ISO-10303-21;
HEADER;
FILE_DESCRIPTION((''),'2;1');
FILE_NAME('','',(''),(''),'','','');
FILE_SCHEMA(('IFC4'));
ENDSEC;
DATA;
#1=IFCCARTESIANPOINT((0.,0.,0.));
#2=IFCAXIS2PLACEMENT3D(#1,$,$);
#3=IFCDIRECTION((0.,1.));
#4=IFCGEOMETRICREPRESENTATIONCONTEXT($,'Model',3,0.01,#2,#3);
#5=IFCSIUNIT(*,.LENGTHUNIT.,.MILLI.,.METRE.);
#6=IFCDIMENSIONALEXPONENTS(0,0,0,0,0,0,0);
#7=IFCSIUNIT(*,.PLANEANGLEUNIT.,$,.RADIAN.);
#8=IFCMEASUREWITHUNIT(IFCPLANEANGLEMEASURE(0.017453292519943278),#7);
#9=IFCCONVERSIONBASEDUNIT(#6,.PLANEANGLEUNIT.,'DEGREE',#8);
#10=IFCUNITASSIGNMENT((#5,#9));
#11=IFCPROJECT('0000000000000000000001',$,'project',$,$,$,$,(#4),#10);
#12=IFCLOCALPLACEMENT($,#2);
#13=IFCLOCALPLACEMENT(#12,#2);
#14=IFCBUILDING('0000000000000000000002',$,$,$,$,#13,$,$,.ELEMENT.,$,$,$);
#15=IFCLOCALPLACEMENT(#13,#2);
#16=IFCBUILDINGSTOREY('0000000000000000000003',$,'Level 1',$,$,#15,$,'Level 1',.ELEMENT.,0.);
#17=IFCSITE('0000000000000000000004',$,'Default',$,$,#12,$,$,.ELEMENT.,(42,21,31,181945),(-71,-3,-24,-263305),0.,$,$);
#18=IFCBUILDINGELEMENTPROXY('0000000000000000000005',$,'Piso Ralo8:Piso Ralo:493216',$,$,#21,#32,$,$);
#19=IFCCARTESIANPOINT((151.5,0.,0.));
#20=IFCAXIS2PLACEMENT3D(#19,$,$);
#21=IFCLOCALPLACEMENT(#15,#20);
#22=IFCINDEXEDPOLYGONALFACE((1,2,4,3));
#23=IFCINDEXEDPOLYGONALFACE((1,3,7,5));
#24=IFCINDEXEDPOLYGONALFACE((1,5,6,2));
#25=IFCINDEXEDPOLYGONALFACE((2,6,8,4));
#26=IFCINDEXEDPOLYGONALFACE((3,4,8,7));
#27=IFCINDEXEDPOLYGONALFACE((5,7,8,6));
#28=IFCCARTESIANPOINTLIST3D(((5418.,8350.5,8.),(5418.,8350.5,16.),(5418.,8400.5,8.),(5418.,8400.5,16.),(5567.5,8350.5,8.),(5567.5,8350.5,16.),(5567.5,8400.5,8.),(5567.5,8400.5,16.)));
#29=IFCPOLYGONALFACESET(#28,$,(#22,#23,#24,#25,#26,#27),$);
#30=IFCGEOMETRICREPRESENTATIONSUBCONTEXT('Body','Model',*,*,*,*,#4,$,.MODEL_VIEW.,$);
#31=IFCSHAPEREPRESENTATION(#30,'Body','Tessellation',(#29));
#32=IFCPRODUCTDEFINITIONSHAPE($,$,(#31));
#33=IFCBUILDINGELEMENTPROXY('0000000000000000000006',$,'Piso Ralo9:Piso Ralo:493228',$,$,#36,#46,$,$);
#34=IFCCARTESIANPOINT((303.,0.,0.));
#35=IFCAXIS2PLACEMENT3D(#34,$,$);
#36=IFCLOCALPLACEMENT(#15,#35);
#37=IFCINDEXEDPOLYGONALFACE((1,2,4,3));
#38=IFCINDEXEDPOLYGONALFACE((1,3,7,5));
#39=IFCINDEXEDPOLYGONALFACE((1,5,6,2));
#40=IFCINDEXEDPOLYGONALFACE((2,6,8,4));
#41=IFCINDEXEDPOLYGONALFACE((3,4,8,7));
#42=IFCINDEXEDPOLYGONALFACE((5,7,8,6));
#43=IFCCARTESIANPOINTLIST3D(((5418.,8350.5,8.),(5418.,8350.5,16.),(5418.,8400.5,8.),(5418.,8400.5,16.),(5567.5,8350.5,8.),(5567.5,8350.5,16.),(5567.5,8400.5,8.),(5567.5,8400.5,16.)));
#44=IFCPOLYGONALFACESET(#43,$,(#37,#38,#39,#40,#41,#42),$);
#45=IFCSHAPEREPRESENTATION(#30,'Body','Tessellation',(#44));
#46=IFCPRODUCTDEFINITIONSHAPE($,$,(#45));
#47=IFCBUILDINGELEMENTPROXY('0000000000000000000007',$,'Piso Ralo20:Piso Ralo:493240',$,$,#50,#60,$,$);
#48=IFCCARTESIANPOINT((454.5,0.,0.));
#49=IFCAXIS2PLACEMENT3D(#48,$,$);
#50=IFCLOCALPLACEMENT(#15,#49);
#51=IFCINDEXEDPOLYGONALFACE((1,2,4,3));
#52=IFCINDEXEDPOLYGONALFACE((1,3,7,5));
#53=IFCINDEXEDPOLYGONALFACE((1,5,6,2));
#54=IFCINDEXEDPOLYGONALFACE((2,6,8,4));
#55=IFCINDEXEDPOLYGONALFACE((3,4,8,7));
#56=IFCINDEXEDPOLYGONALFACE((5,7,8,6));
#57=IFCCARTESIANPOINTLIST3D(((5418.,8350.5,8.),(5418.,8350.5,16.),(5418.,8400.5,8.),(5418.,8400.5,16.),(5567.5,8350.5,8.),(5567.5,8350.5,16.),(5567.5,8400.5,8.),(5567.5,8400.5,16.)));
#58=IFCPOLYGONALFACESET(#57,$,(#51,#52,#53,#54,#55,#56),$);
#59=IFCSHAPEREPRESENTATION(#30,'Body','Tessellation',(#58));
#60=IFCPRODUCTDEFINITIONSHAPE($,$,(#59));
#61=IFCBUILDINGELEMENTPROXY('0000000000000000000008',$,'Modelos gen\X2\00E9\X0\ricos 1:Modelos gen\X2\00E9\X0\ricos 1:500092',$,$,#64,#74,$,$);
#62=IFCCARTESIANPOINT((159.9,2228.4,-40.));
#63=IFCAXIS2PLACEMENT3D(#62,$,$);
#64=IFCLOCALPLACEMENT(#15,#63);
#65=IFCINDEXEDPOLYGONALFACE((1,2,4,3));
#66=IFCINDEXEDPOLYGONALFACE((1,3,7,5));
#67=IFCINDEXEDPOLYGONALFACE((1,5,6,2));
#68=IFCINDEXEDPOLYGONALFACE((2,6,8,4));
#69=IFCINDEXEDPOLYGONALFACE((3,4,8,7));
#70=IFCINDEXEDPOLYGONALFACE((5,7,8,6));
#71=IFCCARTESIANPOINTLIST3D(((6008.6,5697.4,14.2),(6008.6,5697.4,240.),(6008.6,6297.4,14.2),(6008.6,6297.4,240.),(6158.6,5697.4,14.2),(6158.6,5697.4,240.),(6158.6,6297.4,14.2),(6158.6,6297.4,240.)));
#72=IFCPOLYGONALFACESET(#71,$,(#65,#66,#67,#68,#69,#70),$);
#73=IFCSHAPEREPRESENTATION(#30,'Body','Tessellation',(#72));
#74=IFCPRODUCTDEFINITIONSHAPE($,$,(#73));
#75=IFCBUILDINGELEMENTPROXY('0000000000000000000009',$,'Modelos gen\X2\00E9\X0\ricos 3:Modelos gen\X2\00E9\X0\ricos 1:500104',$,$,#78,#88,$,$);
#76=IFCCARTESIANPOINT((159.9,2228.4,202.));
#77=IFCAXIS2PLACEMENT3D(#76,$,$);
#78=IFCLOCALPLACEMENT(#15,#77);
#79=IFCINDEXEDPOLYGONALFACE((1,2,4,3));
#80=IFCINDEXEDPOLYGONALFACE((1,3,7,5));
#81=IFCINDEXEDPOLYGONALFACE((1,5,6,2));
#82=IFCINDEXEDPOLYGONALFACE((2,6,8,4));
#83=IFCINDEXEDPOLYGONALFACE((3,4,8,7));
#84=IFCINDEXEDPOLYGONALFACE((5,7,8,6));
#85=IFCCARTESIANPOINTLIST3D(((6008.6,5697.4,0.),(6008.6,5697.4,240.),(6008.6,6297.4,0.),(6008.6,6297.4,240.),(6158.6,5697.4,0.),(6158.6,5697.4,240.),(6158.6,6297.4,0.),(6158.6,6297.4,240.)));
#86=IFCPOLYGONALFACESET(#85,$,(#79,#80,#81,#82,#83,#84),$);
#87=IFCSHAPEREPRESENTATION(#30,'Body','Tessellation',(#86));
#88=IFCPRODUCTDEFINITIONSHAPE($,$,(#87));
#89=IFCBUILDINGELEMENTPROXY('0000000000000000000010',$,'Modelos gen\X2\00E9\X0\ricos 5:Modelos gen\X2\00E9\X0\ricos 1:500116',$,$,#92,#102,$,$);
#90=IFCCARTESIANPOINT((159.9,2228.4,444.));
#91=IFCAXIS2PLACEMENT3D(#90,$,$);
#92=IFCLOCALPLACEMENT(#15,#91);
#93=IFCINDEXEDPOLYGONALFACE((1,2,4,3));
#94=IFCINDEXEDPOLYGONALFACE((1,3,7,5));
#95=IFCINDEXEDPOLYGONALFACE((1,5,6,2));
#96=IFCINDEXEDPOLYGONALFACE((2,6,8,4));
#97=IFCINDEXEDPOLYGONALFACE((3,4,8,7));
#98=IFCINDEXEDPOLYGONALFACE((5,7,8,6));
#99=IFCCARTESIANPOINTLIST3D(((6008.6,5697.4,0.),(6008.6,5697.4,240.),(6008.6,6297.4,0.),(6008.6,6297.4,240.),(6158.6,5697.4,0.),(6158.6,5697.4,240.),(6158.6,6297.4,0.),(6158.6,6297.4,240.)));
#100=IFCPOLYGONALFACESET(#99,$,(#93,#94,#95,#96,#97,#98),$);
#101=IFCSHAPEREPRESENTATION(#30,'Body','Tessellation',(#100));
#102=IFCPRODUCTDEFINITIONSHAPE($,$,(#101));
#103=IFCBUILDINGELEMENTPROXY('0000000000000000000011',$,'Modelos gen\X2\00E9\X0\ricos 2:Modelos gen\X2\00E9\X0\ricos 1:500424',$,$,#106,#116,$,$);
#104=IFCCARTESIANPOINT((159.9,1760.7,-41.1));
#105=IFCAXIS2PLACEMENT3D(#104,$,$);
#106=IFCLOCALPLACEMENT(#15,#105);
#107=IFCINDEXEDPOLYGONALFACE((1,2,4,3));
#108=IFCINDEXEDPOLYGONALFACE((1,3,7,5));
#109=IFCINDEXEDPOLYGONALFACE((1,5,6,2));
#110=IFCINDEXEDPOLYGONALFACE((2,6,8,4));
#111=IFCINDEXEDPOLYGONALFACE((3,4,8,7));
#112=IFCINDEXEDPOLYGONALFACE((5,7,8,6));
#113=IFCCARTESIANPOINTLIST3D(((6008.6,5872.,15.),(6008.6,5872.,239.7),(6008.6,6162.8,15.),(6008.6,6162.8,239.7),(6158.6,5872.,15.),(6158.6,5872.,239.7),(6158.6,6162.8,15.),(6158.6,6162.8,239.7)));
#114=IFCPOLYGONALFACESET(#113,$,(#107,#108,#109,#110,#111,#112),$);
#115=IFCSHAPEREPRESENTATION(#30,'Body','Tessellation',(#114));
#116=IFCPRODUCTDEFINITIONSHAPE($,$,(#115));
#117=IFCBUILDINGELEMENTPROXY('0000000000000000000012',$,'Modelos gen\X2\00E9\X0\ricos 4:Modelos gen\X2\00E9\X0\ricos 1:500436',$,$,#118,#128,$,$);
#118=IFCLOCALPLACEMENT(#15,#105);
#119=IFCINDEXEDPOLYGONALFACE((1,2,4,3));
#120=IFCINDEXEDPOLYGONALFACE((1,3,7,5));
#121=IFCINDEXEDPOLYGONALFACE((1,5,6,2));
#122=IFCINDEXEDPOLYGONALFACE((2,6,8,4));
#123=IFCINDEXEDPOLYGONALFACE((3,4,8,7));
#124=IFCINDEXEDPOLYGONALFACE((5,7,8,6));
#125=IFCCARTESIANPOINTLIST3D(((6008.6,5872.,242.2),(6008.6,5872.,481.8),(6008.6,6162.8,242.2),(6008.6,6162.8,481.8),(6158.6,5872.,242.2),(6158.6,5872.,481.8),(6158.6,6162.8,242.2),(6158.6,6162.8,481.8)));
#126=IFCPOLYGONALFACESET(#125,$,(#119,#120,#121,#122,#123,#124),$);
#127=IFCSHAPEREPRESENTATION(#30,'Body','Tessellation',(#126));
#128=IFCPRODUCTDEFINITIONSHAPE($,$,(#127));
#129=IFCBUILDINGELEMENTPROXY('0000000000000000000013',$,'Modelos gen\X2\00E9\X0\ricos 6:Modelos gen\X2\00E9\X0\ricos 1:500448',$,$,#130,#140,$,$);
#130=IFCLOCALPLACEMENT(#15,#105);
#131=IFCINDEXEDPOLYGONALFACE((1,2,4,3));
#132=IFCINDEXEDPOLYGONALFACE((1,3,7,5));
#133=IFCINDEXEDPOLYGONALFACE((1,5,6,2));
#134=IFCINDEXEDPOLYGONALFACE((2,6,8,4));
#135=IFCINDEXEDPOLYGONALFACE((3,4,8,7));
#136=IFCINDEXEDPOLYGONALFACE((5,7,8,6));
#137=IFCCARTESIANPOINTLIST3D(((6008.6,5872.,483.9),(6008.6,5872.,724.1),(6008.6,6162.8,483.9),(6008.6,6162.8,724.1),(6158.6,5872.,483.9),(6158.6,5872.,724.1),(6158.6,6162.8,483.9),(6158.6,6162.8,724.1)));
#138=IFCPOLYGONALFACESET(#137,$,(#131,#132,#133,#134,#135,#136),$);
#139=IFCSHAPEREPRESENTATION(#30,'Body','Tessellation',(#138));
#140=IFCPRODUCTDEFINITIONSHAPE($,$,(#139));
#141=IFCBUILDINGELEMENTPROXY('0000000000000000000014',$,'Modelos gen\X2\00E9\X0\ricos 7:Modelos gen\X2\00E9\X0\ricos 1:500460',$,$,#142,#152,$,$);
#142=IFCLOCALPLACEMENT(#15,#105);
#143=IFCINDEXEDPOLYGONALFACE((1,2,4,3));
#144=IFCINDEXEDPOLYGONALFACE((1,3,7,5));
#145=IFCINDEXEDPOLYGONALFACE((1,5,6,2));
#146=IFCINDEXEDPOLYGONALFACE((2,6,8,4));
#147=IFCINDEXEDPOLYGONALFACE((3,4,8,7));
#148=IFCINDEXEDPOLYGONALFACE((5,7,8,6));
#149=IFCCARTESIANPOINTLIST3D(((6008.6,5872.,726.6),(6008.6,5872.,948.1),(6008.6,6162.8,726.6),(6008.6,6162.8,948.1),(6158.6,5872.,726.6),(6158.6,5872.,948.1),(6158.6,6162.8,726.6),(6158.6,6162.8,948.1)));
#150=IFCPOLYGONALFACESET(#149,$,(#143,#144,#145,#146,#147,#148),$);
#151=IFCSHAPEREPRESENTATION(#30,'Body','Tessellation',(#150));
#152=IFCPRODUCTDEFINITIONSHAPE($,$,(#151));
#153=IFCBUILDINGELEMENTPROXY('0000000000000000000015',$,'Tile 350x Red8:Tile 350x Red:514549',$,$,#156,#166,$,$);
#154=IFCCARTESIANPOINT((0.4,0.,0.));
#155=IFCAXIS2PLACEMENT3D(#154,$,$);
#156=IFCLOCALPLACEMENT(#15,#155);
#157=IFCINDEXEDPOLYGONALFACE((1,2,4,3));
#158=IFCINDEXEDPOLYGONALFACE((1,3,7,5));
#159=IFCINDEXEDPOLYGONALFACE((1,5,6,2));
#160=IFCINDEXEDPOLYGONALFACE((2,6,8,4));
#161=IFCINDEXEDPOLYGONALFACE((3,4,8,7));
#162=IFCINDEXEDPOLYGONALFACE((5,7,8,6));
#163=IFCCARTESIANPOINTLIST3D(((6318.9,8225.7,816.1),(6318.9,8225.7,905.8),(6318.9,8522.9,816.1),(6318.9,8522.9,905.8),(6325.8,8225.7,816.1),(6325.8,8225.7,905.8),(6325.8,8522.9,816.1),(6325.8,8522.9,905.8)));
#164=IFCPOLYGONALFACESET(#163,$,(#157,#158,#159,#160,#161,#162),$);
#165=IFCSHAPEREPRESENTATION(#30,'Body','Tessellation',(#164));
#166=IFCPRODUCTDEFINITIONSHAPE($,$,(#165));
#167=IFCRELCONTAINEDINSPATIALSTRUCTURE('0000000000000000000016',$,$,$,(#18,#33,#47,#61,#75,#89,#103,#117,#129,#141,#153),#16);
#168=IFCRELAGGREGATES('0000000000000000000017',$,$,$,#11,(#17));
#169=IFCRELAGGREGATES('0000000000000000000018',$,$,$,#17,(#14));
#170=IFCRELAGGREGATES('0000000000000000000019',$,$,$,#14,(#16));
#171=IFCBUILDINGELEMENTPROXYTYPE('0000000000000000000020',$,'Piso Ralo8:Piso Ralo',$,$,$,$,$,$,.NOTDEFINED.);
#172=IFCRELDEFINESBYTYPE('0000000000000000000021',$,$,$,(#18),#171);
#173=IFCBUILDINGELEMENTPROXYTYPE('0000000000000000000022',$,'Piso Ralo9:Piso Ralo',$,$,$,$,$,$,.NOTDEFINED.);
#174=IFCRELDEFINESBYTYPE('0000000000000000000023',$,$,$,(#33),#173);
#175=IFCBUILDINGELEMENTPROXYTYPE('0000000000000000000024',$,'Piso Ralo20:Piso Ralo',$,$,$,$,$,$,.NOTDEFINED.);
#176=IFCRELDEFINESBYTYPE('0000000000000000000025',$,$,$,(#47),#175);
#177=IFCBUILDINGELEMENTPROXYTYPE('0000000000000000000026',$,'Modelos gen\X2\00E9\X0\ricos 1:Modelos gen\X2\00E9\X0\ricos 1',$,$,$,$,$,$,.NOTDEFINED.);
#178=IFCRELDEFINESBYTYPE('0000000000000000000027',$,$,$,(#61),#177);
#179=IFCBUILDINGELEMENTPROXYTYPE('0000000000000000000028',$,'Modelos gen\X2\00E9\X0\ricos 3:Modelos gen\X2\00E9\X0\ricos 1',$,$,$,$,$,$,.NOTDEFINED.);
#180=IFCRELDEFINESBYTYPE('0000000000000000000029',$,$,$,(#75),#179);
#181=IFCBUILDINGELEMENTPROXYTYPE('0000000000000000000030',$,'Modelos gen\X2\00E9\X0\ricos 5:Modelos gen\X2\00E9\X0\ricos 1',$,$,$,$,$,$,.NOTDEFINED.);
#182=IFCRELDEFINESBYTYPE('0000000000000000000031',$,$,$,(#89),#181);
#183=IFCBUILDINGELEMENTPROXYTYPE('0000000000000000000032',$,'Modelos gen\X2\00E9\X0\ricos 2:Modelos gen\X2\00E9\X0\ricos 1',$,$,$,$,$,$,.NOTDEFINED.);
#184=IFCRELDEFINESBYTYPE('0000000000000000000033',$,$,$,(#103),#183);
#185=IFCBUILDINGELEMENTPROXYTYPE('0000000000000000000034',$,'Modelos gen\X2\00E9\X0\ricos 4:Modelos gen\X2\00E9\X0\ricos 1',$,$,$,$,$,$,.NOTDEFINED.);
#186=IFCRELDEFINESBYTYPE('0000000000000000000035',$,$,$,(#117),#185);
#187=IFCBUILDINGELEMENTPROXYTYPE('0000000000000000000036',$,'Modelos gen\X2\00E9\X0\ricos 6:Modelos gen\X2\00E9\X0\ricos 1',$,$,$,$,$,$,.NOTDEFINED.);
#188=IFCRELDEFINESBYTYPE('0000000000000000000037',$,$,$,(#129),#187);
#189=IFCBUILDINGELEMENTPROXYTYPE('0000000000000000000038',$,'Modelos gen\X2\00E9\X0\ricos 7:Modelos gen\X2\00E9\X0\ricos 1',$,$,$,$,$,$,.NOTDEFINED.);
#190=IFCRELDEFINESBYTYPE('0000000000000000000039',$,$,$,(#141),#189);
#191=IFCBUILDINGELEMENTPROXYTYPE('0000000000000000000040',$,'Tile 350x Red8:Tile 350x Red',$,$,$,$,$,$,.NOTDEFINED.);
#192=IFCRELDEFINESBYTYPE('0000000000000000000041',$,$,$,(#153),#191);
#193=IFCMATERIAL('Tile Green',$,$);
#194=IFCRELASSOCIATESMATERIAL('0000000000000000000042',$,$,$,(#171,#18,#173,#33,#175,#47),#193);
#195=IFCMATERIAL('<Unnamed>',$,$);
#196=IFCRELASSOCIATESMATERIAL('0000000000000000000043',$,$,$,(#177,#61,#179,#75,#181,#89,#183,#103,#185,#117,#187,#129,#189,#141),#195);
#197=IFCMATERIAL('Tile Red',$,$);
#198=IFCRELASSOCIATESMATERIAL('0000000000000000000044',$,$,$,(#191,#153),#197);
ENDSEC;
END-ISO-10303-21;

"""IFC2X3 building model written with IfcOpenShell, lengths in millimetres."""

from ifc_helpers import new_model, entity, si_unit, converted_unit, direction, frame, frame_2d, origin, origin_2d_with_axis, place, context, subcontext, project, spatial, rectangle, extrude, source, transform, mapped, material, type_object, type_shapes, element, save


model = new_model("IFC2X3")

# Units and contexts
model_context = context("Model", 3, precision=0.01, world=origin(), true_north=direction((0.0, 1.0)))
body_context = subcontext(model_context, "Body", "Model", "MODEL_VIEW")
ifc_project = project(units=[si_unit("LENGTHUNIT", "METRE", prefix="MILLI"), converted_unit("PLANEANGLEUNIT", "DEGREE", entity("IfcPlaneAngleMeasure", 0.017453292519943278), si_unit("PLANEANGLEUNIT", "RADIAN"), dimensions=[0, 0, 0, 0, 0, 0, 0])], contexts=[model_context])

# Site, building, storey
site_placement = place(None, origin())
site = spatial("IfcSite", under=ifc_project, at=site_placement, Name="Default", CompositionType="ELEMENT", RefLatitude=(42, 21, 31, 181945), RefLongitude=(-71, -3, -24, -263305), RefElevation=0.0)
building_placement = place(site_placement, origin())
building = spatial("IfcBuilding", under=site, at=building_placement, CompositionType="ELEMENT")
storey_placement = place(building_placement, origin())
storey = spatial("IfcBuildingStorey", under=building, at=storey_placement, Name="Level 1", LongName="Level 1", CompositionType="ELEMENT", Elevation=0.0)

# Building element proxies
ifc_material_1 = material(Name="Tile Green")
building_element_proxy_type_1 = type_object("IfcBuildingElementProxyType", Name="Piso Ralo8:Piso Ralo", PredefinedType="NOTDEFINED", material=ifc_material_1)
shared_shape_1 = source(origin(), body_context, "Body", "SweptSolid", [
    extrude(rectangle(XDim=149.5, YDim=50.0, at=frame_2d((0.0, 0.0), x_axis=(1.0, 0.0))), frame((5492.7, 8375.5, 8.0), z_axis=(0.0, 0.0, 1.0), x_axis=(-1.0, 0.0, 0.0)), (0.0, 0.0, 1.0), 8.0),
])
type_shapes(building_element_proxy_type_1, [shared_shape_1])
proxy_1_placement = place(storey_placement, frame((151.5, 0.0, 0.0)))
element("IfcBuildingElementProxy", 1, at=proxy_1_placement, inside=storey, type_object=building_element_proxy_type_1, material=ifc_material_1, Name="Piso Ralo8:Piso Ralo:493216", context=body_context, shape_type="MappedRepresentation", body=[
    mapped(shared_shape_1, transform((0.0, 0.0, 0.0), scale=1.0)),
])
building_element_proxy_type_2 = type_object("IfcBuildingElementProxyType", Name="Piso Ralo9:Piso Ralo", PredefinedType="NOTDEFINED", material=ifc_material_1)
shared_shape_2 = source(origin(), body_context, "Body", "SweptSolid", [
    extrude(rectangle(XDim=149.5, YDim=50.0, at=frame_2d((0.0, 0.0), x_axis=(1.0, 0.0))), frame((5492.7, 8375.5, 8.0), z_axis=(0.0, 0.0, 1.0), x_axis=(-1.0, 0.0, 0.0)), (0.0, 0.0, 1.0), 8.0),
])
type_shapes(building_element_proxy_type_2, [shared_shape_2])
proxy_2_placement = place(storey_placement, frame((303.0, 0.0, 0.0)))
element("IfcBuildingElementProxy", 2, at=proxy_2_placement, inside=storey, type_object=building_element_proxy_type_2, material=ifc_material_1, Name="Piso Ralo9:Piso Ralo:493228", context=body_context, shape_type="MappedRepresentation", body=[
    mapped(shared_shape_2, transform((0.0, 0.0, 0.0), scale=1.0)),
])
building_element_proxy_type_3 = type_object("IfcBuildingElementProxyType", Name="Piso Ralo20:Piso Ralo", PredefinedType="NOTDEFINED", material=ifc_material_1)
shared_shape_3 = source(origin(), body_context, "Body", "SweptSolid", [
    extrude(rectangle(XDim=149.5, YDim=50.0, at=frame_2d((0.0, 0.0), x_axis=(1.0, 0.0))), frame((5492.7, 8375.5, 8.0), z_axis=(0.0, 0.0, 1.0), x_axis=(-1.0, 0.0, 0.0)), (0.0, 0.0, 1.0), 8.0),
])
type_shapes(building_element_proxy_type_3, [shared_shape_3])
proxy_3_placement = place(storey_placement, frame((454.5, 0.0, 0.0)))
element("IfcBuildingElementProxy", 3, at=proxy_3_placement, inside=storey, type_object=building_element_proxy_type_3, material=ifc_material_1, Name="Piso Ralo20:Piso Ralo:493240", context=body_context, shape_type="MappedRepresentation", body=[
    mapped(shared_shape_3, transform((0.0, 0.0, 0.0), scale=1.0)),
])
ifc_material_2 = material(Name="<Unnamed>")
building_element_proxy_type_4 = type_object("IfcBuildingElementProxyType", Name="Modelos genéricos 1:Modelos genéricos 1", PredefinedType="NOTDEFINED", material=ifc_material_2)
shared_shape_4 = source(origin(), body_context, "Body", "SweptSolid", [
    extrude(rectangle(XDim=150.0, YDim=600.0, at=origin_2d_with_axis()), frame((6083.6, 5997.4, 14.2), z_axis=(0.0, 0.0, 1.0), x_axis=(-1.0, 0.0, 0.0)), (0.0, 0.0, 1.0), 225.8),
])
type_shapes(building_element_proxy_type_4, [shared_shape_4])
proxy_4_placement = place(storey_placement, frame((159.9, 2228.4, -40.0)))
element("IfcBuildingElementProxy", 4, at=proxy_4_placement, inside=storey, type_object=building_element_proxy_type_4, material=ifc_material_2, Name="Modelos genéricos 1:Modelos genéricos 1:500092", context=body_context, shape_type="MappedRepresentation", body=[
    mapped(shared_shape_4, transform((0.0, 0.0, 0.0), scale=1.0)),
])
building_element_proxy_type_5 = type_object("IfcBuildingElementProxyType", Name="Modelos genéricos 3:Modelos genéricos 1", PredefinedType="NOTDEFINED", material=ifc_material_2)
shared_shape_5 = source(origin(), body_context, "Body", "SweptSolid", [
    extrude(rectangle(XDim=150.0, YDim=600.0, at=origin_2d_with_axis()), frame((6083.6, 5997.4, 0.0), z_axis=(0.0, 0.0, 1.0), x_axis=(-1.0, 0.0, 0.0)), (0.0, 0.0, 1.0), 240.0),
])
type_shapes(building_element_proxy_type_5, [shared_shape_5])
proxy_5_placement = place(storey_placement, frame((159.9, 2228.4, 202.0)))
element("IfcBuildingElementProxy", 5, at=proxy_5_placement, inside=storey, type_object=building_element_proxy_type_5, material=ifc_material_2, Name="Modelos genéricos 3:Modelos genéricos 1:500104", context=body_context, shape_type="MappedRepresentation", body=[
    mapped(shared_shape_5, transform((0.0, 0.0, 0.0), scale=1.0)),
])
building_element_proxy_type_6 = type_object("IfcBuildingElementProxyType", Name="Modelos genéricos 5:Modelos genéricos 1", PredefinedType="NOTDEFINED", material=ifc_material_2)
shared_shape_6 = source(origin(), body_context, "Body", "SweptSolid", [
    extrude(rectangle(XDim=150.0, YDim=600.0, at=origin_2d_with_axis()), frame((6083.6, 5997.4, 0.0), z_axis=(0.0, 0.0, 1.0), x_axis=(-1.0, 0.0, 0.0)), (0.0, 0.0, 1.0), 240.0),
])
type_shapes(building_element_proxy_type_6, [shared_shape_6])
proxy_6_placement = place(storey_placement, frame((159.9, 2228.4, 444.0)))
element("IfcBuildingElementProxy", 6, at=proxy_6_placement, inside=storey, type_object=building_element_proxy_type_6, material=ifc_material_2, Name="Modelos genéricos 5:Modelos genéricos 1:500116", context=body_context, shape_type="MappedRepresentation", body=[
    mapped(shared_shape_6, transform((0.0, 0.0, 0.0), scale=1.0)),
])
building_element_proxy_type_7 = type_object("IfcBuildingElementProxyType", Name="Modelos genéricos 2:Modelos genéricos 1", PredefinedType="NOTDEFINED", material=ifc_material_2)
shared_shape_7 = source(origin(), body_context, "Body", "SweptSolid", [
    extrude(rectangle(XDim=150.0, YDim=290.8, at=frame_2d((0.0, 0.0), x_axis=(1.0, 0.0))), frame((6083.6, 6017.4, 15.0), z_axis=(0.0, 0.0, 1.0), x_axis=(-1.0, 0.0, 0.0)), (0.0, 0.0, 1.0), 224.7),
])
type_shapes(building_element_proxy_type_7, [shared_shape_7])
proxy_7_placement = place(storey_placement, frame((159.9, 1760.7, -41.1)))
element("IfcBuildingElementProxy", 7, at=proxy_7_placement, inside=storey, type_object=building_element_proxy_type_7, material=ifc_material_2, Name="Modelos genéricos 2:Modelos genéricos 1:500424", context=body_context, shape_type="MappedRepresentation", body=[
    mapped(shared_shape_7, transform((0.0, 0.0, 0.0), scale=1.0)),
])
building_element_proxy_type_8 = type_object("IfcBuildingElementProxyType", Name="Modelos genéricos 4:Modelos genéricos 1", PredefinedType="NOTDEFINED", material=ifc_material_2)
shared_shape_8 = source(origin(), body_context, "Body", "SweptSolid", [
    extrude(rectangle(XDim=150.0, YDim=290.8, at=frame_2d((0.0, 0.0), x_axis=(1.0, 0.0))), frame((6083.6, 6017.4, 242.2), z_axis=(0.0, 0.0, 1.0), x_axis=(-1.0, 0.0, 0.0)), (0.0, 0.0, 1.0), 239.6),
])
type_shapes(building_element_proxy_type_8, [shared_shape_8])
proxy_8_placement = place(storey_placement, frame((159.9, 1760.7, -41.1)))
element("IfcBuildingElementProxy", 8, at=proxy_8_placement, inside=storey, type_object=building_element_proxy_type_8, material=ifc_material_2, Name="Modelos genéricos 4:Modelos genéricos 1:500436", context=body_context, shape_type="MappedRepresentation", body=[
    mapped(shared_shape_8, transform((0.0, 0.0, 0.0), scale=1.0)),
])
building_element_proxy_type_9 = type_object("IfcBuildingElementProxyType", Name="Modelos genéricos 6:Modelos genéricos 1", PredefinedType="NOTDEFINED", material=ifc_material_2)
shared_shape_9 = source(origin(), body_context, "Body", "SweptSolid", [
    extrude(rectangle(XDim=150.0, YDim=290.8, at=frame_2d((0.0, 0.0), x_axis=(1.0, 0.0))), frame((6083.6, 6017.4, 483.9), z_axis=(0.0, 0.0, 1.0), x_axis=(-1.0, 0.0, 0.0)), (0.0, 0.0, 1.0), 240.2),
])
type_shapes(building_element_proxy_type_9, [shared_shape_9])
proxy_9_placement = place(storey_placement, frame((159.9, 1760.7, -41.1)))
element("IfcBuildingElementProxy", 9, at=proxy_9_placement, inside=storey, type_object=building_element_proxy_type_9, material=ifc_material_2, Name="Modelos genéricos 6:Modelos genéricos 1:500448", context=body_context, shape_type="MappedRepresentation", body=[
    mapped(shared_shape_9, transform((0.0, 0.0, 0.0), scale=1.0)),
])
building_element_proxy_type_10 = type_object("IfcBuildingElementProxyType", Name="Modelos genéricos 7:Modelos genéricos 1", PredefinedType="NOTDEFINED", material=ifc_material_2)
shared_shape_10 = source(origin(), body_context, "Body", "SweptSolid", [
    extrude(rectangle(XDim=150.0, YDim=290.8, at=frame_2d((0.0, 0.0), x_axis=(1.0, 0.0))), frame((6083.6, 6017.4, 726.6), z_axis=(0.0, 0.0, 1.0), x_axis=(-1.0, 0.0, 0.0)), (0.0, 0.0, 1.0), 221.5),
])
type_shapes(building_element_proxy_type_10, [shared_shape_10])
proxy_10_placement = place(storey_placement, frame((159.9, 1760.7, -41.1)))
element("IfcBuildingElementProxy", 10, at=proxy_10_placement, inside=storey, type_object=building_element_proxy_type_10, material=ifc_material_2, Name="Modelos genéricos 7:Modelos genéricos 1:500460", context=body_context, shape_type="MappedRepresentation", body=[
    mapped(shared_shape_10, transform((0.0, 0.0, 0.0), scale=1.0)),
])
ifc_material_3 = material(Name="Tile Red")
building_element_proxy_type_11 = type_object("IfcBuildingElementProxyType", Name="Tile 350x Red8:Tile 350x Red", PredefinedType="NOTDEFINED", material=ifc_material_3)
shared_shape_11 = source(origin(), body_context, "Body", "SweptSolid", [
    extrude(rectangle(XDim=6.9, YDim=297.1, at=frame_2d((0.0, 0.0), x_axis=(1.0, 0.0))), frame((6322.4, 8374.3, 816.1), z_axis=(0.0, 0.0, 1.0), x_axis=(-1.0, 0.0, 0.0)), (0.0, 0.0, 1.0), 89.7),
])
type_shapes(building_element_proxy_type_11, [shared_shape_11])
proxy_11_placement = place(storey_placement, frame((0.4, 0.0, 0.0)))
element("IfcBuildingElementProxy", 11, at=proxy_11_placement, inside=storey, type_object=building_element_proxy_type_11, material=ifc_material_3, Name="Tile 350x Red8:Tile 350x Red:514549", context=body_context, shape_type="MappedRepresentation", body=[
    mapped(shared_shape_11, transform((0.0, 0.0, 0.0), scale=1.0)),
])

save(model, "model.ifc")
